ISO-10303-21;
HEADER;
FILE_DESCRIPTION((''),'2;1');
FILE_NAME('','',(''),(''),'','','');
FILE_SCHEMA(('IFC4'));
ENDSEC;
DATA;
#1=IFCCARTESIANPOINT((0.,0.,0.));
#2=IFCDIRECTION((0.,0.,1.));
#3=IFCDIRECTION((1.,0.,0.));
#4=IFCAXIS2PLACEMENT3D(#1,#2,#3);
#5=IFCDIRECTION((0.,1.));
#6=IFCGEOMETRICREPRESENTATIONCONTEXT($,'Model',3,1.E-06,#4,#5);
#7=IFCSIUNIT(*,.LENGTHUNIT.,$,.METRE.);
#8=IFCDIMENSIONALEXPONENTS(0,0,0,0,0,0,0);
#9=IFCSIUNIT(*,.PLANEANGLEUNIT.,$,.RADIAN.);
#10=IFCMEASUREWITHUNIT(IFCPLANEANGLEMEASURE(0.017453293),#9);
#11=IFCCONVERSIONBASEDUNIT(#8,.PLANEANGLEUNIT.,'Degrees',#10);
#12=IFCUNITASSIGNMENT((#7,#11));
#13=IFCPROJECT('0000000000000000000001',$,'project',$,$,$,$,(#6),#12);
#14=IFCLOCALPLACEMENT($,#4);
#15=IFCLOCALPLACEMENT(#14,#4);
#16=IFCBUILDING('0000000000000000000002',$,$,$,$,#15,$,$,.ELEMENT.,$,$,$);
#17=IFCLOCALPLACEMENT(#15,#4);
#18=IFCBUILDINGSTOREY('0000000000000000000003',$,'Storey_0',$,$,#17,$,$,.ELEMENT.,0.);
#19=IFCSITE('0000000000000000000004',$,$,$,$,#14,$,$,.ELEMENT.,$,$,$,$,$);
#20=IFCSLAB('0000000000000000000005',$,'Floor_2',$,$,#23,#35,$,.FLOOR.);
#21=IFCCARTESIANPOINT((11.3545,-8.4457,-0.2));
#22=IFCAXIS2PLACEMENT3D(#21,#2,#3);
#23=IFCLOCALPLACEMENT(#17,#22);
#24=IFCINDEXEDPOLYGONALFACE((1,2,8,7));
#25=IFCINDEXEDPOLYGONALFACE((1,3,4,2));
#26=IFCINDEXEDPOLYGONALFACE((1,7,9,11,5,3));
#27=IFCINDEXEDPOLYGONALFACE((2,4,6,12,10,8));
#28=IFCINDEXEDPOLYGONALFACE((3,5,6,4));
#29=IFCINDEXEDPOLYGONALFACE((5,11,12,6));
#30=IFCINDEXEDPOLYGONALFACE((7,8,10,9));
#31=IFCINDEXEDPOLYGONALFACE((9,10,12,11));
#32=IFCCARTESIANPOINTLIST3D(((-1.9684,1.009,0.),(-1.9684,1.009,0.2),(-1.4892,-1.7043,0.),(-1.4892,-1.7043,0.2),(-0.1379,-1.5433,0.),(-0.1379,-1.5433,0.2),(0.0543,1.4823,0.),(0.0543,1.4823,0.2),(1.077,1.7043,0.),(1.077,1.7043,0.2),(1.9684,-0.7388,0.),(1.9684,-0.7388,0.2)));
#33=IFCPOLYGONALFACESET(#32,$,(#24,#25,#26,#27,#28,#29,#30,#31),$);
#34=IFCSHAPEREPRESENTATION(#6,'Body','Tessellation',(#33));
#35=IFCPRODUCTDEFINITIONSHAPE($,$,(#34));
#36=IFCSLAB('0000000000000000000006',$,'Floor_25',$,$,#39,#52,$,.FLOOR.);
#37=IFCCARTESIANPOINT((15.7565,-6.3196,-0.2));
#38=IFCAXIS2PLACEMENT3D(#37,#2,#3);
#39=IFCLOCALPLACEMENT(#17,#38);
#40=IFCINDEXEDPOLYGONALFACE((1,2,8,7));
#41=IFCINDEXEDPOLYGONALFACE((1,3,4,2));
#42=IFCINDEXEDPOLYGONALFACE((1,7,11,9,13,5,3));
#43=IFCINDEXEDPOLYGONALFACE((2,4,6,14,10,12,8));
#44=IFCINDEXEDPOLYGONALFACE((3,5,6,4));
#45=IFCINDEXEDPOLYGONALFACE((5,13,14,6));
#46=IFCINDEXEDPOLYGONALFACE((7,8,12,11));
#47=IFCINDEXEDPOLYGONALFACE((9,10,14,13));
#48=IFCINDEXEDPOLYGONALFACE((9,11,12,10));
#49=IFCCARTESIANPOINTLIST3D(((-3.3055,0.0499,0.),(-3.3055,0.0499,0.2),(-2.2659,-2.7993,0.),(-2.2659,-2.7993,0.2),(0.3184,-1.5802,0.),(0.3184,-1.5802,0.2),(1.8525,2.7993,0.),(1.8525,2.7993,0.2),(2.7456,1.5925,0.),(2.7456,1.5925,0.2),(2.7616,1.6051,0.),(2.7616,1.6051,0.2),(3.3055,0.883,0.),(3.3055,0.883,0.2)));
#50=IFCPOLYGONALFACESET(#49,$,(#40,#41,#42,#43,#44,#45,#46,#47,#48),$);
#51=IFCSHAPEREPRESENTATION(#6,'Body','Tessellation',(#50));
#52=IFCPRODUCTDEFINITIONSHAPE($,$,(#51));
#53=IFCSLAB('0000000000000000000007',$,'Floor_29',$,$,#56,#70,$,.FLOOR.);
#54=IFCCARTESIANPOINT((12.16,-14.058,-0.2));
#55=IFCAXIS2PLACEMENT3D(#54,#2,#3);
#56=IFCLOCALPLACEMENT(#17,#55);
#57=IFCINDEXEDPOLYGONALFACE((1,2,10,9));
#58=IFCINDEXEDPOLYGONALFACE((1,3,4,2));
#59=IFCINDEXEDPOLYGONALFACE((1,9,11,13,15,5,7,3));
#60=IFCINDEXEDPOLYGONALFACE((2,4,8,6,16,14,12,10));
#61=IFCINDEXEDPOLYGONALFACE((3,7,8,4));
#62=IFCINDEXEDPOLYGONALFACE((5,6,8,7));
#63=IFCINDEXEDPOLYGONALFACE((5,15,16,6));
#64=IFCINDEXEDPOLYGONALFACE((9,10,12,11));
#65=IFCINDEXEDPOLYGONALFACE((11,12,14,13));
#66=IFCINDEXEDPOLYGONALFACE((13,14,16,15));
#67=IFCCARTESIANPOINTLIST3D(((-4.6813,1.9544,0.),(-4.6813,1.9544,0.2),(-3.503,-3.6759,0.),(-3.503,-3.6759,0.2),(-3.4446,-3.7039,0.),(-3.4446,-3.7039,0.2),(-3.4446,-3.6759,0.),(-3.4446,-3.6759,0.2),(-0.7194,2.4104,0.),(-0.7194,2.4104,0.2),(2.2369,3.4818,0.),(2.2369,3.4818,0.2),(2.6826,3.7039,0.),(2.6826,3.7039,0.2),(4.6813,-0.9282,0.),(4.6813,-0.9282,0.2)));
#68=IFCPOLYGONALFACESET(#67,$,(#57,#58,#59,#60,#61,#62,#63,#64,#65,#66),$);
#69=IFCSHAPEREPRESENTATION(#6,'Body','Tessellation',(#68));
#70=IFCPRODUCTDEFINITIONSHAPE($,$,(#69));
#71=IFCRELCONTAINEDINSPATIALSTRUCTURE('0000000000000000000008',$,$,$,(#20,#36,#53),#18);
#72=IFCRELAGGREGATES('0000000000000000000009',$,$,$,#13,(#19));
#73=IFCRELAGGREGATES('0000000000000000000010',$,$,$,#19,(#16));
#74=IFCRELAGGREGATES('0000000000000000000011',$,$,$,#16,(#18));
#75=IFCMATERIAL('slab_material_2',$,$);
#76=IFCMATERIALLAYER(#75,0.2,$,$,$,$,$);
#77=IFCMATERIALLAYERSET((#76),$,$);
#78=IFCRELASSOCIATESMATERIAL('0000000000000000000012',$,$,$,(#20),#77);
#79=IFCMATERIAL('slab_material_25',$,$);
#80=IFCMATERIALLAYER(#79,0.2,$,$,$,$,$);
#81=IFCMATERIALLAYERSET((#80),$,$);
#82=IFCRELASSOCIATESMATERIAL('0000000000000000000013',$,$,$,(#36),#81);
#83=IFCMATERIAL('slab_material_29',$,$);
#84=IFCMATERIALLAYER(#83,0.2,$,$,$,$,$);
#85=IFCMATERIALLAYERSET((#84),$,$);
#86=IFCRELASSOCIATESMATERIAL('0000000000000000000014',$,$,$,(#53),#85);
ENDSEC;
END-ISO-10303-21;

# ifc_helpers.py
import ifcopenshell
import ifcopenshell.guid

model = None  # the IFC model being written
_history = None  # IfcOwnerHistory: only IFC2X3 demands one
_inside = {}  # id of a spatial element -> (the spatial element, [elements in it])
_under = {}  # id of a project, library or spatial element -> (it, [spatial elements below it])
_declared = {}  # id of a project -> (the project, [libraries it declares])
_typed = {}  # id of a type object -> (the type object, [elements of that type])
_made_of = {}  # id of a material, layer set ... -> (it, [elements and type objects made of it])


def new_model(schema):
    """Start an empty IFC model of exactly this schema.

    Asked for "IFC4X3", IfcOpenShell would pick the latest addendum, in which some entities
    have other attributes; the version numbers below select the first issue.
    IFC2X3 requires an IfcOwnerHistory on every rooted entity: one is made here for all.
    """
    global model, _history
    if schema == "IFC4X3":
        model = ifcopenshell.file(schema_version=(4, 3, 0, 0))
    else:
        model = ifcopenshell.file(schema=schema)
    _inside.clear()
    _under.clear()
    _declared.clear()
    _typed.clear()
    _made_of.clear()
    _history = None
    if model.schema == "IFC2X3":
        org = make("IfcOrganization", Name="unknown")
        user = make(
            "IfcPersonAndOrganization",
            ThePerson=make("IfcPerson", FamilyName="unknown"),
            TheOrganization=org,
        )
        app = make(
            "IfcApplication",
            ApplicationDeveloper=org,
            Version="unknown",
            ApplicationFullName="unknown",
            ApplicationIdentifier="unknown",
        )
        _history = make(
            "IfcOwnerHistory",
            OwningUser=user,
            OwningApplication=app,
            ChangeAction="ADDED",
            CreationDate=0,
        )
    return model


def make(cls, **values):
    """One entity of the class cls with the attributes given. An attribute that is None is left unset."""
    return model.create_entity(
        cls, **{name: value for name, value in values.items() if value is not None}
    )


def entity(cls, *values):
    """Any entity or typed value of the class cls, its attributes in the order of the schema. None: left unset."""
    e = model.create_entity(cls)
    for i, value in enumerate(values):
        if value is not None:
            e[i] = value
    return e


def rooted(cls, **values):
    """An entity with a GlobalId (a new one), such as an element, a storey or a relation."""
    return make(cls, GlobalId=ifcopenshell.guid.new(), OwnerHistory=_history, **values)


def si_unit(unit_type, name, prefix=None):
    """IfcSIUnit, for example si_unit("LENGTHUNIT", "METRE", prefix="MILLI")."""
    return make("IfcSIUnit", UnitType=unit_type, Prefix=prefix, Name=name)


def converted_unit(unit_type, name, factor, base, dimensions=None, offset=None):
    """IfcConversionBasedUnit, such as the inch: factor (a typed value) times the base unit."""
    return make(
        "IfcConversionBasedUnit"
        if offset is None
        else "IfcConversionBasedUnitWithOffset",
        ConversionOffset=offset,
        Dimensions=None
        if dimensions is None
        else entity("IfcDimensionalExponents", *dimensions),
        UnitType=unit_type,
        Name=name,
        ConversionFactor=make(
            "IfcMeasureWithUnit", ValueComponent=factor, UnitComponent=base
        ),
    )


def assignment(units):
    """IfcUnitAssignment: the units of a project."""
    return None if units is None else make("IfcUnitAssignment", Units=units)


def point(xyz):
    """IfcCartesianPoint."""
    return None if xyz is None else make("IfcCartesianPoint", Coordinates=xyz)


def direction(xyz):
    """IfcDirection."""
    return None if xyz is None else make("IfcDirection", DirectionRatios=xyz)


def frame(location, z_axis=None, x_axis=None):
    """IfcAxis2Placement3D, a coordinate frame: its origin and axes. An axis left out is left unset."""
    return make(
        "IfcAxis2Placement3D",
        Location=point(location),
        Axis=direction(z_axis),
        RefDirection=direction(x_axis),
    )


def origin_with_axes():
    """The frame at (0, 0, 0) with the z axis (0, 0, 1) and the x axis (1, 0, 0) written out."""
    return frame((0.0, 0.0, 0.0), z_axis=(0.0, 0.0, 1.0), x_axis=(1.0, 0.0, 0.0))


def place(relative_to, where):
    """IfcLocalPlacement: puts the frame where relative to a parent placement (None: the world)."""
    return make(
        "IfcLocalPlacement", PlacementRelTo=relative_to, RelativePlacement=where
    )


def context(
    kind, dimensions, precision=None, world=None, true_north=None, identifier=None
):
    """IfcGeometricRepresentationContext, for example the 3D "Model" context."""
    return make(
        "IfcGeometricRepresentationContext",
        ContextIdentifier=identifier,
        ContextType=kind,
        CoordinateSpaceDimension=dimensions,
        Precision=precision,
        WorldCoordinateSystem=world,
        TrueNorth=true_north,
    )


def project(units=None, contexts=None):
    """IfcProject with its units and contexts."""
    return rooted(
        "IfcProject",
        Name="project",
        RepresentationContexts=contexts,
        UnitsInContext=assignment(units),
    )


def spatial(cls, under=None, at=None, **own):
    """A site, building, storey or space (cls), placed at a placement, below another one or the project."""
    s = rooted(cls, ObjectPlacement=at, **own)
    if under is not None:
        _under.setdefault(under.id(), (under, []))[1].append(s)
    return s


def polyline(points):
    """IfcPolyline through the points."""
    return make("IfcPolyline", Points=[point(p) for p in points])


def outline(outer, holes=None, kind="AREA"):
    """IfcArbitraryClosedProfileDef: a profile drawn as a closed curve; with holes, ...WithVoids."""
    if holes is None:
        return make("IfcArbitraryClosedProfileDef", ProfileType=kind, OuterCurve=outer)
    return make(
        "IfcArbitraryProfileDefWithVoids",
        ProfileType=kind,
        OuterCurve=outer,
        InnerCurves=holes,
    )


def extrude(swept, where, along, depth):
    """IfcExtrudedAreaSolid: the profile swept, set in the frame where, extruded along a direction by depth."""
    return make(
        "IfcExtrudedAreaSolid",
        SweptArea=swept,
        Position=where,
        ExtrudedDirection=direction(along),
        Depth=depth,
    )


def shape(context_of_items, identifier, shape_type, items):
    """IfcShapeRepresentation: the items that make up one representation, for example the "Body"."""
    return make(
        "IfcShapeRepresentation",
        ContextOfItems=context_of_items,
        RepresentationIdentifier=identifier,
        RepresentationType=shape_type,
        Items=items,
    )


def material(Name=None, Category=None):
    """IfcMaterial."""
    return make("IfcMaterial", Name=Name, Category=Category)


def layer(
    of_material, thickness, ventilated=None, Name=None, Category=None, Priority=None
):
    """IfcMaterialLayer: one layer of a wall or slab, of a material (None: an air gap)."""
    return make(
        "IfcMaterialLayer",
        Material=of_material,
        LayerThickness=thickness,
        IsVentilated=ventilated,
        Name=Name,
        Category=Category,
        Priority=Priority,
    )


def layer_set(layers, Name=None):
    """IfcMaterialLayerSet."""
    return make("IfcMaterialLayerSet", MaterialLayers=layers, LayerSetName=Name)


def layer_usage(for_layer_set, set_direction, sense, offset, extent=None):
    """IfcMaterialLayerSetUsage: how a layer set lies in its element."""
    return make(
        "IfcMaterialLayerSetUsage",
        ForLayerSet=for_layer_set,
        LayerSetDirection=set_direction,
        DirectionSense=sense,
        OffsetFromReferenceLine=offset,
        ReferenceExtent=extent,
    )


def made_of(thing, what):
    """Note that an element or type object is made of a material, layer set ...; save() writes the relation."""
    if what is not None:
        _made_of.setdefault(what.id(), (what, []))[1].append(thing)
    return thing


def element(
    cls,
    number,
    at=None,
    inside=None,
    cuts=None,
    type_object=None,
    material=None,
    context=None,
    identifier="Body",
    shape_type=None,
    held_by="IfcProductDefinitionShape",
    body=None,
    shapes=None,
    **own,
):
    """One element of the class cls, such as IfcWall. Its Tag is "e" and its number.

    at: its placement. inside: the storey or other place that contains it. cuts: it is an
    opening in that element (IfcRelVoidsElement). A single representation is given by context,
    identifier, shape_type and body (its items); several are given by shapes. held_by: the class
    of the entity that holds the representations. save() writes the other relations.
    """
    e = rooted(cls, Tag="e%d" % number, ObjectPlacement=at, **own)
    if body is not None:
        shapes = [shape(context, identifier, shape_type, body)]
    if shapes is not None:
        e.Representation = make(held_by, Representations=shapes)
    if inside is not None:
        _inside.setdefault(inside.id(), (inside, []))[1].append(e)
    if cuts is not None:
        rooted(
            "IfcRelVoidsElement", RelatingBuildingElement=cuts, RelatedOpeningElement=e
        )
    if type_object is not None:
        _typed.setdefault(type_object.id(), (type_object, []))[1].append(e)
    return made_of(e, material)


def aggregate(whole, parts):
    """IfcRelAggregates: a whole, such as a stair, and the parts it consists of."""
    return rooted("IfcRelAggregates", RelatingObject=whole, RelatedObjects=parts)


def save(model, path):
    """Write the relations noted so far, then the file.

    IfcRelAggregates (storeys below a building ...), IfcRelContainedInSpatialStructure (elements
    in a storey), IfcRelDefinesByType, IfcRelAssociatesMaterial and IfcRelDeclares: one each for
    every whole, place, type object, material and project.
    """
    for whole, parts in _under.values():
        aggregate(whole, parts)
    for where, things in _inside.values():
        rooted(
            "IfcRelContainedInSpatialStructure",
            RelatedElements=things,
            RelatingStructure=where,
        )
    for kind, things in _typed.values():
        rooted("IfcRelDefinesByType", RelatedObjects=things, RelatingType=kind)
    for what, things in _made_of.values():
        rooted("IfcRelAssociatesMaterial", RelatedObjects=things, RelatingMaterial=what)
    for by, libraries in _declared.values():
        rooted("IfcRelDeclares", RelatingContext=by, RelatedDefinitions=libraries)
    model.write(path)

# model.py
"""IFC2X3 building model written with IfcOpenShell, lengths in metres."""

from ifc_helpers import new_model, entity, si_unit, converted_unit, direction, frame, origin_with_axes, place, context, project, spatial, polyline, outline, extrude, material, layer, layer_set, layer_usage, element, save


model = new_model("IFC2X3")

# Units and contexts
model_context = context("Model", 3, precision=1e-06, world=origin_with_axes(), true_north=direction((0.0, 1.0)))
ifc_project = project(units=[si_unit("LENGTHUNIT", "METRE"), converted_unit("PLANEANGLEUNIT", "Degrees", entity("IfcPlaneAngleMeasure", 0.017453293), si_unit("PLANEANGLEUNIT", "RADIAN"), dimensions=[0, 0, 0, 0, 0, 0, 0])], contexts=[model_context])

# Site, building, storey
site_placement = place(None, origin_with_axes())
site = spatial("IfcSite", under=ifc_project, at=site_placement, CompositionType="ELEMENT")
building_placement = place(site_placement, origin_with_axes())
building = spatial("IfcBuilding", under=site, at=building_placement, CompositionType="ELEMENT")
storey_placement = place(building_placement, origin_with_axes())
storey = spatial("IfcBuildingStorey", under=building, at=storey_placement, Name="Storey_0", CompositionType="ELEMENT", Elevation=0.0)

# Slabs
ifc_material_1 = material(Name="slab_material_2")
ifc_layer_1 = layer(ifc_material_1, 0.2)
ifc_layer_set_1 = layer_set([ifc_layer_1])
ifc_layer_usage_1 = layer_usage(ifc_layer_set_1, "AXIS3", "POSITIVE", 0.0)
slab_1_placement = place(storey_placement, frame((11.3545, -8.4457, -0.2), z_axis=(0.0, 0.0, 1.0), x_axis=(1.0, 0.0, 0.0)))
element("IfcSlab", 1, at=slab_1_placement, inside=storey, material=ifc_layer_usage_1, Name="Floor_2", PredefinedType="FLOOR", context=model_context, shape_type="SweptSolid", body=[
    extrude(outline(polyline([(1.9684, -0.7388), (-0.1379, -1.5433), (-1.4892, -1.7043), (-1.9684, 1.009), (0.0543, 1.4823), (1.077, 1.7043), (1.9684, -0.7388)])), origin_with_axes(), (0.0, 0.0, 1.0), 0.2),
])
ifc_material_2 = material(Name="slab_material_25")
ifc_layer_2 = layer(ifc_material_2, 0.2)
ifc_layer_set_2 = layer_set([ifc_layer_2])
ifc_layer_usage_2 = layer_usage(ifc_layer_set_2, "AXIS3", "POSITIVE", 0.0)
slab_2_placement = place(storey_placement, frame((15.7565, -6.3196, -0.2), z_axis=(0.0, 0.0, 1.0), x_axis=(1.0, 0.0, 0.0)))
element("IfcSlab", 2, at=slab_2_placement, inside=storey, material=ifc_layer_usage_2, Name="Floor_25", PredefinedType="FLOOR", context=model_context, shape_type="SweptSolid", body=[
    extrude(outline(polyline([(2.7616, 1.6051), (2.7456, 1.5925), (3.3055, 0.883), (0.3184, -1.5802), (-2.2659, -2.7993), (-3.3055, 0.0499), (1.8525, 2.7993), (2.7616, 1.6051)])), origin_with_axes(), (0.0, 0.0, 1.0), 0.2),
])
ifc_material_3 = material(Name="slab_material_29")
ifc_layer_3 = layer(ifc_material_3, 0.2)
ifc_layer_set_3 = layer_set([ifc_layer_3])
ifc_layer_usage_3 = layer_usage(ifc_layer_set_3, "AXIS3", "POSITIVE", 0.0)
slab_3_placement = place(storey_placement, frame((12.16, -14.058, -0.2), z_axis=(0.0, 0.0, 1.0), x_axis=(1.0, 0.0, 0.0)))
element("IfcSlab", 3, at=slab_3_placement, inside=storey, material=ifc_layer_usage_3, Name="Floor_29", PredefinedType="FLOOR", context=model_context, shape_type="SweptSolid", body=[
    extrude(outline(polyline([(4.6813, -0.9282), (-3.4446, -3.7039), (-3.4446, -3.6759), (-3.503, -3.6759), (-4.6813, 1.9544), (-0.7194, 2.4104), (2.2369, 3.4818), (2.6826, 3.7039), (4.6813, -0.9282)])), origin_with_axes(), (0.0, 0.0, 1.0), 0.2),
])

save(model, "model.ifc")
